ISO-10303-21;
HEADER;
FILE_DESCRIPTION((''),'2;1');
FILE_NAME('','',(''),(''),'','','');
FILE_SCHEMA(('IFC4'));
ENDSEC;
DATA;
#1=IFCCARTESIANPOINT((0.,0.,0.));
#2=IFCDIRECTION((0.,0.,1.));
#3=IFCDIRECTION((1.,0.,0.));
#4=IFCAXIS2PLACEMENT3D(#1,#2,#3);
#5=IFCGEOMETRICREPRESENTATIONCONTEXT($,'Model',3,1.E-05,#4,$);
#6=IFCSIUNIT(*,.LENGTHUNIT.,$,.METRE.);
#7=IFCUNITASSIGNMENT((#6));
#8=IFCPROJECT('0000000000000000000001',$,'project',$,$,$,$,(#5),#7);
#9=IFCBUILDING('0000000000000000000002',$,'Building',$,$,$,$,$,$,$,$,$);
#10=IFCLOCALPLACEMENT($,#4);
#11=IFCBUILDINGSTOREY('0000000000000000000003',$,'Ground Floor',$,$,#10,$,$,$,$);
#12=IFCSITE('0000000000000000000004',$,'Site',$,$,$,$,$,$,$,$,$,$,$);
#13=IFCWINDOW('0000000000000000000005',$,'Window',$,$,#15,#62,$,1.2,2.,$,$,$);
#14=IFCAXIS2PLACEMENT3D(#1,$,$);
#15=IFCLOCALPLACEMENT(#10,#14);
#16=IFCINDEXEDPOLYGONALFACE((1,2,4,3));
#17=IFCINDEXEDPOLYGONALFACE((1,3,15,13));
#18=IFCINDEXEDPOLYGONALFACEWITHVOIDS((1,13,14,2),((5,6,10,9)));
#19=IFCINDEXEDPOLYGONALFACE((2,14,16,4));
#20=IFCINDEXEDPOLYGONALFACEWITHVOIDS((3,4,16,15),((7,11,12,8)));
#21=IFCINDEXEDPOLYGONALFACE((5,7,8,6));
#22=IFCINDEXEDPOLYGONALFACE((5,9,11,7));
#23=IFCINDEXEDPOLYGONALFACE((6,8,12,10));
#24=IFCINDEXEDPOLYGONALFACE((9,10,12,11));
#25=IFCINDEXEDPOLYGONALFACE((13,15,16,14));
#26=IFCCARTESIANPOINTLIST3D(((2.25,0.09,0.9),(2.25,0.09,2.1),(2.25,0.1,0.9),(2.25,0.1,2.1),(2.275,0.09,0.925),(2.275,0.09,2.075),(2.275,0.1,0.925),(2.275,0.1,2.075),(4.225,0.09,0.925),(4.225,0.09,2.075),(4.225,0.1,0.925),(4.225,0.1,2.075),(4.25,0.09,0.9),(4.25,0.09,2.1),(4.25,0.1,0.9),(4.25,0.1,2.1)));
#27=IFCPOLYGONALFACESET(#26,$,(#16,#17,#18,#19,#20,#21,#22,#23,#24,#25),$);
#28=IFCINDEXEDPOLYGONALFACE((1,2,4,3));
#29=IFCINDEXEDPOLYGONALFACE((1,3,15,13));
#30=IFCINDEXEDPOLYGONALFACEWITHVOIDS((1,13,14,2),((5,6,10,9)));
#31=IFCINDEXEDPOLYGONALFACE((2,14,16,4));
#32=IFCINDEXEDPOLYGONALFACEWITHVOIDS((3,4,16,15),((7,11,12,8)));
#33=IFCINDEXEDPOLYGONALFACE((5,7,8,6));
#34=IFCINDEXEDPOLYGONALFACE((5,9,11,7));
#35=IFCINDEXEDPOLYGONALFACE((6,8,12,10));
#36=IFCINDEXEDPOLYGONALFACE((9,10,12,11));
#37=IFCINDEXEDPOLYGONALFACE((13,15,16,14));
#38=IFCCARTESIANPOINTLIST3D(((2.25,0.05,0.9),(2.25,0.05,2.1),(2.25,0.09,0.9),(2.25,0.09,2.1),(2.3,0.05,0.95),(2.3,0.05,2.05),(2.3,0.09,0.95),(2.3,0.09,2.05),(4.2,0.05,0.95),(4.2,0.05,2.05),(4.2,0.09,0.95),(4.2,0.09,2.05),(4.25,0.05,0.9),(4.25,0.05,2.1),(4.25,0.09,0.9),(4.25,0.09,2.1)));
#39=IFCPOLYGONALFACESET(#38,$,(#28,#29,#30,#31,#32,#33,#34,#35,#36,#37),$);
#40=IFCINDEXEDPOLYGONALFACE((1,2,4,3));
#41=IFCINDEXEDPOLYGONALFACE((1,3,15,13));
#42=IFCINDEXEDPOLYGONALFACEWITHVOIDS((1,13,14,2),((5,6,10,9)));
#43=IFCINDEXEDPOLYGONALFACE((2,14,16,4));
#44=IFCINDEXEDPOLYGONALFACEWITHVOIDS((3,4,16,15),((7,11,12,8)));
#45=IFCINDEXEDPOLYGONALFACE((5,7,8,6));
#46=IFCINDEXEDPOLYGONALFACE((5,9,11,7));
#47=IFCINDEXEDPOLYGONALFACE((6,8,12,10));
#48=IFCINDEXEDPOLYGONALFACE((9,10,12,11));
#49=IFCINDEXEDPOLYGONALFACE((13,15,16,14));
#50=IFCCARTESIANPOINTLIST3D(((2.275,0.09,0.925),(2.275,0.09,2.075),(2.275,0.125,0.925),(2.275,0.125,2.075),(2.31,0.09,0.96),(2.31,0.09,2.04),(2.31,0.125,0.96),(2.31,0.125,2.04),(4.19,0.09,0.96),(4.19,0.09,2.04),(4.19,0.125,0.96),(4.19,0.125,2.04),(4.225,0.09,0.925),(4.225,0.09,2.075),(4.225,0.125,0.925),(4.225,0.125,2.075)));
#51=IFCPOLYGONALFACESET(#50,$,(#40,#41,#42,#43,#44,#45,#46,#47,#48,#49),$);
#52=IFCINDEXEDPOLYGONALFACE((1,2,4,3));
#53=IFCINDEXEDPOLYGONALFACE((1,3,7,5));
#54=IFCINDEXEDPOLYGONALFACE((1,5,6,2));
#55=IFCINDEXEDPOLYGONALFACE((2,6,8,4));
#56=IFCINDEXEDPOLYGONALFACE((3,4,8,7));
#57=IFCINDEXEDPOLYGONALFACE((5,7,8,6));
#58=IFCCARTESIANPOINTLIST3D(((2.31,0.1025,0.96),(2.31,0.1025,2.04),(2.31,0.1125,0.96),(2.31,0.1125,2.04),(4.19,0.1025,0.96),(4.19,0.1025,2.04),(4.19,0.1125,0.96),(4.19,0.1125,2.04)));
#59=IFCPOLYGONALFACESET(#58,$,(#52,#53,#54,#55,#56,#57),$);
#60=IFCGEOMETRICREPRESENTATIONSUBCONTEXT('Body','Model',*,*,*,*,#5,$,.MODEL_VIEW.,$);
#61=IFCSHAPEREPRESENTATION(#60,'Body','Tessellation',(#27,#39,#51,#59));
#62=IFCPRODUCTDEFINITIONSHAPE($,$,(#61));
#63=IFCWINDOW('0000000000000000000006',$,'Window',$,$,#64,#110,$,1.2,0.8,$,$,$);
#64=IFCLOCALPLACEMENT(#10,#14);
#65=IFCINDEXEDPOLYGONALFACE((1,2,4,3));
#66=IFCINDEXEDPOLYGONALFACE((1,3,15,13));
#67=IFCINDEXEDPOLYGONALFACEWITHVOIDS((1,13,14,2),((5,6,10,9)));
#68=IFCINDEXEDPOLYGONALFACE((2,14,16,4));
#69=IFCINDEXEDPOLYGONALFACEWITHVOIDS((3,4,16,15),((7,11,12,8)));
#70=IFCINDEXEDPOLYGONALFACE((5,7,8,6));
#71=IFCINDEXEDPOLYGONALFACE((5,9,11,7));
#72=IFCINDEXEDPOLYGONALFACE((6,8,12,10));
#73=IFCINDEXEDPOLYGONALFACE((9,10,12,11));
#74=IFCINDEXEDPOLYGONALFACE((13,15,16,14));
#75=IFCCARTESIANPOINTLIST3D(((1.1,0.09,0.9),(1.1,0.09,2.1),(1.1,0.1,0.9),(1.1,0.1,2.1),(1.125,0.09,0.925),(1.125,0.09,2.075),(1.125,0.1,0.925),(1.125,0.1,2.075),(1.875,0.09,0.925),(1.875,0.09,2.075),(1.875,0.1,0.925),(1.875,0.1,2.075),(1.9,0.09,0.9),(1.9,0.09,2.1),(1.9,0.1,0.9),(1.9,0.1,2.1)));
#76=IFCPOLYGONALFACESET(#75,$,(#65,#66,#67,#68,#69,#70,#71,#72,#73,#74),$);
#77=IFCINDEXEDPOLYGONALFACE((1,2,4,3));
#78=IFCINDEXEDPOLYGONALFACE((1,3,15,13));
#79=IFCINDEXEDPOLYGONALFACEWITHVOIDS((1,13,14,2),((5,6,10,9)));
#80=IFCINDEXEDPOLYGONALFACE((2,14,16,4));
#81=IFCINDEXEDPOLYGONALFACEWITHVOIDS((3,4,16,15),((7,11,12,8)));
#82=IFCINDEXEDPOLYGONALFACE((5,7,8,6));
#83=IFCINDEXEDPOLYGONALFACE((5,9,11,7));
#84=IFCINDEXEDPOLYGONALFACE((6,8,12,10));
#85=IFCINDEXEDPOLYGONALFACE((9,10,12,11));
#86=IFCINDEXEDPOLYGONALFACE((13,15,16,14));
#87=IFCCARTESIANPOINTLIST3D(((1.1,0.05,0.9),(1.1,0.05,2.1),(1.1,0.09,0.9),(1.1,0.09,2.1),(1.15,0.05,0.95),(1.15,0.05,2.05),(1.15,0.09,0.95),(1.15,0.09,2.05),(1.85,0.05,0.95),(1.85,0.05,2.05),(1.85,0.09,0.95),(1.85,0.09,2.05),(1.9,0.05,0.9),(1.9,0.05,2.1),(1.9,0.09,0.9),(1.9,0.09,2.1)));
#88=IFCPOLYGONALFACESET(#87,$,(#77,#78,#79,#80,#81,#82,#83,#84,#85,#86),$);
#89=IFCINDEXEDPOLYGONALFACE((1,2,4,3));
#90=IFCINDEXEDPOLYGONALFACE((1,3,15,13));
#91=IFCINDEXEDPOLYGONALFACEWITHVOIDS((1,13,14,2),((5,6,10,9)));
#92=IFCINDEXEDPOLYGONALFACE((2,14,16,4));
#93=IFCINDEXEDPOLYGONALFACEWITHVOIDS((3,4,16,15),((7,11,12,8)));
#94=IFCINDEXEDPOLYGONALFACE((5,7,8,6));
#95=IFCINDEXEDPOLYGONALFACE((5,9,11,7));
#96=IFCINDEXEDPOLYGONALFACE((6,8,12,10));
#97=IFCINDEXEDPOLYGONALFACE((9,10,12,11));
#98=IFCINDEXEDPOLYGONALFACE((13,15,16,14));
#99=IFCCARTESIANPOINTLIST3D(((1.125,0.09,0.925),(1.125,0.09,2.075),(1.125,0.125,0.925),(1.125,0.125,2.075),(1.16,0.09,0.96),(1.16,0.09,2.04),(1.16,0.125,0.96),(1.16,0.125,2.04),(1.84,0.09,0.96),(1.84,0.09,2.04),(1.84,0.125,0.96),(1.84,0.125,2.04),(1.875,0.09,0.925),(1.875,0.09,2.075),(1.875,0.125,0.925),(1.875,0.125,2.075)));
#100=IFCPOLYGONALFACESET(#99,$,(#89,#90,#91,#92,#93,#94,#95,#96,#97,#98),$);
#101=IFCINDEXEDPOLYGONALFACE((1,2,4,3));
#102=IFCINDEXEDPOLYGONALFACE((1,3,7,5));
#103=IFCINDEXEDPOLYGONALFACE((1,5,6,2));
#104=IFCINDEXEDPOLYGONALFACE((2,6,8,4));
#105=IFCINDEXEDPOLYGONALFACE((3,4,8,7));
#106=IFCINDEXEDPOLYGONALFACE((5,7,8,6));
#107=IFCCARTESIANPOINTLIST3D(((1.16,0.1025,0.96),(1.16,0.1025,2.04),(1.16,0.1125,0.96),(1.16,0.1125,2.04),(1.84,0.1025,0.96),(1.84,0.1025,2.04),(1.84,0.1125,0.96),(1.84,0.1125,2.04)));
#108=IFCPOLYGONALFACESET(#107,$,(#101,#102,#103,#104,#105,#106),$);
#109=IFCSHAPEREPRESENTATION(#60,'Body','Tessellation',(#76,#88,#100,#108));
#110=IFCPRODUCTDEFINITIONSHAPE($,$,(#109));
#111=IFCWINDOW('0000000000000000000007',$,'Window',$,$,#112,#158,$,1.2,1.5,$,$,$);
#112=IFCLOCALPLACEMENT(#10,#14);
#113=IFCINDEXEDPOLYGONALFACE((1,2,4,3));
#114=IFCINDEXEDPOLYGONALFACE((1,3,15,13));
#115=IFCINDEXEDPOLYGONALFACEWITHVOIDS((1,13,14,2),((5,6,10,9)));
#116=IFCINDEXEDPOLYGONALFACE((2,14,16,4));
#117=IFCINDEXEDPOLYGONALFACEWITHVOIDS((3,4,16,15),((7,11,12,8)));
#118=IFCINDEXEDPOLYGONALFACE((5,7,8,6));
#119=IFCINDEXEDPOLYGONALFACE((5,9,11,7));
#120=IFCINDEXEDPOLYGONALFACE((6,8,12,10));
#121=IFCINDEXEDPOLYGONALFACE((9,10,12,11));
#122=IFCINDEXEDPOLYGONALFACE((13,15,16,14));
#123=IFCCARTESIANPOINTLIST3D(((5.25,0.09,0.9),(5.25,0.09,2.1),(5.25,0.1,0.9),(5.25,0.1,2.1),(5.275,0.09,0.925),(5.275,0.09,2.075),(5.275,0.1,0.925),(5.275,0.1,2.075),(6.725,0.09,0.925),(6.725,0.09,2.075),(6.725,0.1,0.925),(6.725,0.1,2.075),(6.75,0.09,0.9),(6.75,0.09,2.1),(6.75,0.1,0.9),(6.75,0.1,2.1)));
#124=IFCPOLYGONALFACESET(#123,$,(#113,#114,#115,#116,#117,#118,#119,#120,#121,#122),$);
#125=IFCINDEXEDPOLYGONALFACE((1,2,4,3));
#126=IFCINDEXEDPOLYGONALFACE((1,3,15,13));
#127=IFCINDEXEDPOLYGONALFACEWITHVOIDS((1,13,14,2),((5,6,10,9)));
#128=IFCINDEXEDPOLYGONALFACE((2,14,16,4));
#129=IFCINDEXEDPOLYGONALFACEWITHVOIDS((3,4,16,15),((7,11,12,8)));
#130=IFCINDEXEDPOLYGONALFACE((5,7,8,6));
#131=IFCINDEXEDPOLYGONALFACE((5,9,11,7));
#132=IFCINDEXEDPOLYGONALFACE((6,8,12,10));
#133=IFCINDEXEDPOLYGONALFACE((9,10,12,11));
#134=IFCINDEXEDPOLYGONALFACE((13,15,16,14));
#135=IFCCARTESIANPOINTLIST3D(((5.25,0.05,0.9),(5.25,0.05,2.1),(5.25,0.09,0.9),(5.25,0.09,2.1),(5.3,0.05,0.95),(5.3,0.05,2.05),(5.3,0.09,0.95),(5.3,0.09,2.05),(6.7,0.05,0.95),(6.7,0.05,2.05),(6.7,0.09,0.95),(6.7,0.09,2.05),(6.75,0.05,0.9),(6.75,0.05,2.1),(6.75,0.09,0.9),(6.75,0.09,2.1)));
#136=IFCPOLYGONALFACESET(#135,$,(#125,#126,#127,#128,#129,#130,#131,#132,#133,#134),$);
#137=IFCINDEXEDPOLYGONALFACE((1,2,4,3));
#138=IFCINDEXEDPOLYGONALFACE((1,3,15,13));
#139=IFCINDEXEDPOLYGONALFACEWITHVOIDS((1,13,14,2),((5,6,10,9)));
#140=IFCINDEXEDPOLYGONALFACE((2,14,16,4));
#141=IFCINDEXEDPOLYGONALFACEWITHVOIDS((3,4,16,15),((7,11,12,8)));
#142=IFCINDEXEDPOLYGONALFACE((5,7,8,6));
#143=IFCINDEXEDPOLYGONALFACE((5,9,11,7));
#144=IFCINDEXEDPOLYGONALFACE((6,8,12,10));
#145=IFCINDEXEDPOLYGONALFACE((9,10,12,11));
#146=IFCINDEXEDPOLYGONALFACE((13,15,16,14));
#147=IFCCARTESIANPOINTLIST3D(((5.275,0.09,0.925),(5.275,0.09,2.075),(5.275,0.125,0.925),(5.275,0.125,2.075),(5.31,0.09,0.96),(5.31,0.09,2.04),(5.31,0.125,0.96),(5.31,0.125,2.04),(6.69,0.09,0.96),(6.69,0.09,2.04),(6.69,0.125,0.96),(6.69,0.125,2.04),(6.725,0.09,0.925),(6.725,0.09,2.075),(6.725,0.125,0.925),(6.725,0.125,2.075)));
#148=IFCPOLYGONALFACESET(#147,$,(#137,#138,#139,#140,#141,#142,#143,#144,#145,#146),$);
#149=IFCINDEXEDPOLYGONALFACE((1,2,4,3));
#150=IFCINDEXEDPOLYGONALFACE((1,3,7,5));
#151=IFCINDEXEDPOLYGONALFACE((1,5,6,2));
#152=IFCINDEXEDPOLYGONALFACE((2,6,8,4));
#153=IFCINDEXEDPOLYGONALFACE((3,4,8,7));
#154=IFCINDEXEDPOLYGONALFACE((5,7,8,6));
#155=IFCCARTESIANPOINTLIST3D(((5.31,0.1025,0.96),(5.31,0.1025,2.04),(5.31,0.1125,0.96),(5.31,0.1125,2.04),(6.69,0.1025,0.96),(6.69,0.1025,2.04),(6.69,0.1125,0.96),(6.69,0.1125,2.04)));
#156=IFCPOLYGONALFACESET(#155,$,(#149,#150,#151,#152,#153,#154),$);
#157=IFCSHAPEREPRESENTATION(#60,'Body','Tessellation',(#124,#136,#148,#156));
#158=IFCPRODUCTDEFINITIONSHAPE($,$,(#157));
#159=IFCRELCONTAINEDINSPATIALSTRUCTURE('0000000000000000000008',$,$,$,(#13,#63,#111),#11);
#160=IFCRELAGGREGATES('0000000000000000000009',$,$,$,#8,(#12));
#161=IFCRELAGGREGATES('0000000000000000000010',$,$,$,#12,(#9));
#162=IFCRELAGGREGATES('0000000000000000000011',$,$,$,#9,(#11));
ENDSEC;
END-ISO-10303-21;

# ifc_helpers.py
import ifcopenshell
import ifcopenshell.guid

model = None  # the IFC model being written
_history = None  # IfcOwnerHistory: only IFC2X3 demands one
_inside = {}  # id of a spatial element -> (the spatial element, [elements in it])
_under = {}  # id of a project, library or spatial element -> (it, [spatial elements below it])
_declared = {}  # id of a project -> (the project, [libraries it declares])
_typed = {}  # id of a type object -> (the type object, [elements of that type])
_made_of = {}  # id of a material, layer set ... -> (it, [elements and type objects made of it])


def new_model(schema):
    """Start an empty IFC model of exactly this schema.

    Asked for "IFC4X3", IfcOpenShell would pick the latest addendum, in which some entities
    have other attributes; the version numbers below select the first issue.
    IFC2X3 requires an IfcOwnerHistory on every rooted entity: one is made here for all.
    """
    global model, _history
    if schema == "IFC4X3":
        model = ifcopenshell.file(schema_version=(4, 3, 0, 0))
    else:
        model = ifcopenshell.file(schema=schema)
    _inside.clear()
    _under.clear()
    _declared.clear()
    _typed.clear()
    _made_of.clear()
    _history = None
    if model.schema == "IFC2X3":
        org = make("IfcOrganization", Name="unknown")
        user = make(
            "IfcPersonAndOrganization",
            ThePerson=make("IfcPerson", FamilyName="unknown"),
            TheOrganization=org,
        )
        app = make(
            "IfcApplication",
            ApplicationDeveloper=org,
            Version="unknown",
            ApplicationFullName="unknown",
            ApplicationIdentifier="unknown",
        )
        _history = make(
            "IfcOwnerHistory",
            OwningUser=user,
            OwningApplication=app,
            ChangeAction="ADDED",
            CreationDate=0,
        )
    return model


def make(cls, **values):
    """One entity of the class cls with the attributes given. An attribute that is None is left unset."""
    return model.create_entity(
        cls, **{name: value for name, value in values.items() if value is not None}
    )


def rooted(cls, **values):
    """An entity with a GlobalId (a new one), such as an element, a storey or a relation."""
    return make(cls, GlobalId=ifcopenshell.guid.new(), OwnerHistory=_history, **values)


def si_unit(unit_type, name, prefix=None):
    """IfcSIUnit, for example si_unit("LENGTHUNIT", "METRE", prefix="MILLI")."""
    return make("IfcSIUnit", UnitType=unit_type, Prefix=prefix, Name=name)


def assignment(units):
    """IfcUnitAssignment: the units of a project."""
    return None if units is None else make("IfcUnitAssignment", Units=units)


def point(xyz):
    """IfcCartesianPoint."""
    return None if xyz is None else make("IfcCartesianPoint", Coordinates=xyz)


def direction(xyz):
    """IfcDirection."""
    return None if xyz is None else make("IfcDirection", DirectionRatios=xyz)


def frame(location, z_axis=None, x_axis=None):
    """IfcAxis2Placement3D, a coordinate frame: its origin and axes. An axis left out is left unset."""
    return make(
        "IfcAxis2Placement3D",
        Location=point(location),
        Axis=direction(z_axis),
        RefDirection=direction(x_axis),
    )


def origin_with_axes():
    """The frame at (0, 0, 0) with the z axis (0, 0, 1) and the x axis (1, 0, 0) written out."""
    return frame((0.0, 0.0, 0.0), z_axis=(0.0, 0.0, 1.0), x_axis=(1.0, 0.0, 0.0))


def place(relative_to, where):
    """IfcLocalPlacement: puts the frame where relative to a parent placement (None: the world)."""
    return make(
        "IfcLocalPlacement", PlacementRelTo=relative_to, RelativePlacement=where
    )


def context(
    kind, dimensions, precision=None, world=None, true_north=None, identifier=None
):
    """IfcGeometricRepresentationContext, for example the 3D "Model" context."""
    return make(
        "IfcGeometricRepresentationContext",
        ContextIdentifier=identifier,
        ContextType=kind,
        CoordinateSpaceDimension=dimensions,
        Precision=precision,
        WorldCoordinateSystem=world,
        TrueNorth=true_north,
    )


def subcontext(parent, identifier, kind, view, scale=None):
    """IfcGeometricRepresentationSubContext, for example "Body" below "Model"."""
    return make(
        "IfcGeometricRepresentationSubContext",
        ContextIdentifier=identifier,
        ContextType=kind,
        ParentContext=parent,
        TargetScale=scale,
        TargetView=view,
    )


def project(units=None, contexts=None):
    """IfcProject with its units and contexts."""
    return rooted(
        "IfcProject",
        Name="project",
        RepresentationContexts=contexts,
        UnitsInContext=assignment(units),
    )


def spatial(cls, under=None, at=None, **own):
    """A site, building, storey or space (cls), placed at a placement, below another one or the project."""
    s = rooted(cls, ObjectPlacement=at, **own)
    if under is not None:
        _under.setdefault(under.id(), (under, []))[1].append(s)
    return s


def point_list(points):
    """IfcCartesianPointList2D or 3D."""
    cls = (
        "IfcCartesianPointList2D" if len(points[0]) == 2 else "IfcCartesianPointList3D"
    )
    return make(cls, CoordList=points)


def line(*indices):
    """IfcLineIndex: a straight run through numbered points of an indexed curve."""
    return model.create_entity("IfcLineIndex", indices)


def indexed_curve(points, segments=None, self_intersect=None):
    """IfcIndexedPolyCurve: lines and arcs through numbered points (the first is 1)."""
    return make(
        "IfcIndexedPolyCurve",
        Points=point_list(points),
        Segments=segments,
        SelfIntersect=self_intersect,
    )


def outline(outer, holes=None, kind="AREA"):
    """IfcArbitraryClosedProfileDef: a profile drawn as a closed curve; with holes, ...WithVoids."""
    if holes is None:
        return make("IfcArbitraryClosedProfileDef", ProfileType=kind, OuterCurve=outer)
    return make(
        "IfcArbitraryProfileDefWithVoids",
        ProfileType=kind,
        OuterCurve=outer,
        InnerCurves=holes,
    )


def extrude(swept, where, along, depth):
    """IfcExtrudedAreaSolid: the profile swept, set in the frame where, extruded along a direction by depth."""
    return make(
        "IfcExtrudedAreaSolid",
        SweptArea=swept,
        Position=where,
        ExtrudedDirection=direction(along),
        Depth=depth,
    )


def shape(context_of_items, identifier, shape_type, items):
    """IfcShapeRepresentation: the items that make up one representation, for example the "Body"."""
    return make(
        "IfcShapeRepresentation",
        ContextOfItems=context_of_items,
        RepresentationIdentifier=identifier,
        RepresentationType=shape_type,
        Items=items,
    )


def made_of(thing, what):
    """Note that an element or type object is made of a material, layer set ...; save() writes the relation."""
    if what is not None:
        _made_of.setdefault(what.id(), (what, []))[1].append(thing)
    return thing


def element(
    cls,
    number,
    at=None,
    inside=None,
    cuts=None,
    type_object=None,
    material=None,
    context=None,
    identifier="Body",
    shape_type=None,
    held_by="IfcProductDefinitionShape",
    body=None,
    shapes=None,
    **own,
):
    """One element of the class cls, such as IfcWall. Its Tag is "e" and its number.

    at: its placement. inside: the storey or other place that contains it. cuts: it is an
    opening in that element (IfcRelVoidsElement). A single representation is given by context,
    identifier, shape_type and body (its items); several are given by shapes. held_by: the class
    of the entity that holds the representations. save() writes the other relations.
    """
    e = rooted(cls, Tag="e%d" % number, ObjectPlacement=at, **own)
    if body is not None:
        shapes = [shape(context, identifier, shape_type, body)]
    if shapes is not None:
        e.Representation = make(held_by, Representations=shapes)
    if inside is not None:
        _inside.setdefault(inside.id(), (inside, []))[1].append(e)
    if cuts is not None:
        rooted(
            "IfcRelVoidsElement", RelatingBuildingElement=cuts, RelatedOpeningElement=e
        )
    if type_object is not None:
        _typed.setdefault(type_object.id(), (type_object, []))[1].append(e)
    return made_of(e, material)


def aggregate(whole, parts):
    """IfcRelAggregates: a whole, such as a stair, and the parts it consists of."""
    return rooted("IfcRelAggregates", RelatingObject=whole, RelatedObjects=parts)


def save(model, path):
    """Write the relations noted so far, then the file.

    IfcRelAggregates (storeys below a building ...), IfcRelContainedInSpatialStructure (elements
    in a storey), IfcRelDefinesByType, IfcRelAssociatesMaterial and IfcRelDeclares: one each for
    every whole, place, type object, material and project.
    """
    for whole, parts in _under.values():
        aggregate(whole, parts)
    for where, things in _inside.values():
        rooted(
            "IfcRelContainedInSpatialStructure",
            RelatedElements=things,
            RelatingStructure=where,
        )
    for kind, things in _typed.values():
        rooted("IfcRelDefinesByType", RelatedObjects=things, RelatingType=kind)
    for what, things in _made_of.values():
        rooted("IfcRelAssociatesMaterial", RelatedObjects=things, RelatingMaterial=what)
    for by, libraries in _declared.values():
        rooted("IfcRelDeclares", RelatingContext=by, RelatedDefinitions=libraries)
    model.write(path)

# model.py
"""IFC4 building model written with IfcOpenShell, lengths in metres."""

from ifc_helpers import new_model, si_unit, frame, origin_with_axes, place, context, subcontext, project, spatial, line, indexed_curve, outline, extrude, element, save


model = new_model("IFC4")

# Units and contexts
model_context = context("Model", 3, precision=1e-05, world=origin_with_axes())
body_context = subcontext(model_context, "Body", "Model", "MODEL_VIEW")
ifc_project = project(units=[si_unit("LENGTHUNIT", "METRE")], contexts=[model_context])

# Site, building, storey
site = spatial("IfcSite", under=ifc_project, Name="Site")
building = spatial("IfcBuilding", under=site, Name="Building")
storey_placement = place(None, origin_with_axes())
storey = spatial("IfcBuildingStorey", under=building, at=storey_placement, Name="Ground Floor")

# Windows
window_1_placement = place(storey_placement, frame((2.25, 0.0, 0.9), z_axis=(0.0, 0.0, 1.0), x_axis=(1.0, 0.0, 0.0)))
element("IfcWindow", 1, at=window_1_placement, inside=storey, Name="Window", OverallHeight=1.2, OverallWidth=2.0, context=body_context, shape_type="SweptSolid", body=[
    extrude(outline(indexed_curve([(0.0, 0.0), (2.0, 0.0), (2.0, 1.2), (0.0, 1.2)], segments=[line(1, 2, 3, 4, 1)]), holes=[indexed_curve([(0.025, 0.025), (1.975, 0.025), (1.975, 1.175), (0.025, 1.175)], segments=[line(1, 2, 3, 4, 1)])]), frame((0.0, 0.09, 0.0), z_axis=(0.0, -1.0, 0.0), x_axis=(1.0, 0.0, 0.0)), (0.0, 0.0, -1.0), 0.01),
    extrude(outline(indexed_curve([(0.0, 0.0), (2.0, 0.0), (2.0, 1.2), (0.0, 1.2)], segments=[line(1, 2, 3, 4, 1)]), holes=[indexed_curve([(0.05, 0.05), (1.95, 0.05), (1.95, 1.15), (0.05, 1.15)], segments=[line(1, 2, 3, 4, 1)])]), frame((0.0, 0.05, 0.0), z_axis=(0.0, -1.0, 0.0), x_axis=(1.0, 0.0, 0.0)), (0.0, 0.0, -1.0), 0.04),
    extrude(outline(indexed_curve([(0.0, 0.0), (1.95, 0.0), (1.95, 1.15), (0.0, 1.15)], segments=[line(1, 2, 3, 4, 1)]), holes=[indexed_curve([(0.035, 0.035), (1.915, 0.035), (1.915, 1.115), (0.035, 1.115)], segments=[line(1, 2, 3, 4, 1)])]), frame((0.025, 0.09, 0.025), z_axis=(0.0, -1.0, 0.0), x_axis=(1.0, 0.0, 0.0)), (0.0, 0.0, -1.0), 0.035),
    extrude(outline(indexed_curve([(0.035, 0.035), (1.915, 0.035), (1.915, 1.115), (0.035, 1.115)], segments=[line(1, 2, 3, 4, 1)])), frame((0.025, 0.1025, 0.025), z_axis=(0.0, -1.0, 0.0), x_axis=(1.0, 0.0, 0.0)), (0.0, 0.0, -1.0), 0.01),
])
window_2_placement = place(storey_placement, frame((1.1, 0.0, 0.9), z_axis=(0.0, 0.0, 1.0), x_axis=(1.0, 0.0, 0.0)))
element("IfcWindow", 2, at=window_2_placement, inside=storey, Name="Window", OverallHeight=1.2, OverallWidth=0.8, context=body_context, shape_type="SweptSolid", body=[
    extrude(outline(indexed_curve([(0.0, 0.0), (0.8, 0.0), (0.8, 1.2), (0.0, 1.2)], segments=[line(1, 2, 3, 4, 1)]), holes=[indexed_curve([(0.025, 0.025), (0.775, 0.025), (0.775, 1.175), (0.025, 1.175)], segments=[line(1, 2, 3, 4, 1)])]), frame((0.0, 0.09, 0.0), z_axis=(0.0, -1.0, 0.0), x_axis=(1.0, 0.0, 0.0)), (0.0, 0.0, -1.0), 0.01),
    extrude(outline(indexed_curve([(0.0, 0.0), (0.8, 0.0), (0.8, 1.2), (0.0, 1.2)], segments=[line(1, 2, 3, 4, 1)]), holes=[indexed_curve([(0.05, 0.05), (0.75, 0.05), (0.75, 1.15), (0.05, 1.15)], segments=[line(1, 2, 3, 4, 1)])]), frame((0.0, 0.05, 0.0), z_axis=(0.0, -1.0, 0.0), x_axis=(1.0, 0.0, 0.0)), (0.0, 0.0, -1.0), 0.04),
    extrude(outline(indexed_curve([(0.0, 0.0), (0.75, 0.0), (0.75, 1.15), (0.0, 1.15)], segments=[line(1, 2, 3, 4, 1)]), holes=[indexed_curve([(0.035, 0.035), (0.715, 0.035), (0.715, 1.115), (0.035, 1.115)], segments=[line(1, 2, 3, 4, 1)])]), frame((0.025, 0.09, 0.025), z_axis=(0.0, -1.0, 0.0), x_axis=(1.0, 0.0, 0.0)), (0.0, 0.0, -1.0), 0.035),
    extrude(outline(indexed_curve([(0.035, 0.035), (0.715, 0.035), (0.715, 1.115), (0.035, 1.115)], segments=[line(1, 2, 3, 4, 1)])), frame((0.025, 0.1025, 0.025), z_axis=(0.0, -1.0, 0.0), x_axis=(1.0, 0.0, 0.0)), (0.0, 0.0, -1.0), 0.01),
])
window_3_placement = place(storey_placement, frame((5.25, 0.0, 0.9), z_axis=(0.0, 0.0, 1.0), x_axis=(1.0, 0.0, 0.0)))
element("IfcWindow", 3, at=window_3_placement, inside=storey, Name="Window", OverallHeight=1.2, OverallWidth=1.5, context=body_context, shape_type="SweptSolid", body=[
    extrude(outline(indexed_curve([(0.0, 0.0), (1.5, 0.0), (1.5, 1.2), (0.0, 1.2)], segments=[line(1, 2, 3, 4, 1)]), holes=[indexed_curve([(0.025, 0.025), (1.475, 0.025), (1.475, 1.175), (0.025, 1.175)], segments=[line(1, 2, 3, 4, 1)])]), frame((0.0, 0.09, 0.0), z_axis=(0.0, -1.0, 0.0), x_axis=(1.0, 0.0, 0.0)), (0.0, 0.0, -1.0), 0.01),
    extrude(outline(indexed_curve([(0.0, 0.0), (1.5, 0.0), (1.5, 1.2), (0.0, 1.2)], segments=[line(1, 2, 3, 4, 1)]), holes=[indexed_curve([(0.05, 0.05), (1.45, 0.05), (1.45, 1.15), (0.05, 1.15)], segments=[line(1, 2, 3, 4, 1)])]), frame((0.0, 0.05, 0.0), z_axis=(0.0, -1.0, 0.0), x_axis=(1.0, 0.0, 0.0)), (0.0, 0.0, -1.0), 0.04),
    extrude(outline(indexed_curve([(0.0, 0.0), (1.45, 0.0), (1.45, 1.15), (0.0, 1.15)], segments=[line(1, 2, 3, 4, 1)]), holes=[indexed_curve([(0.035, 0.035), (1.415, 0.035), (1.415, 1.115), (0.035, 1.115)], segments=[line(1, 2, 3, 4, 1)])]), frame((0.025, 0.09, 0.025), z_axis=(0.0, -1.0, 0.0), x_axis=(1.0, 0.0, 0.0)), (0.0, 0.0, -1.0), 0.035),
    extrude(outline(indexed_curve([(0.035, 0.035), (1.415, 0.035), (1.415, 1.115), (0.035, 1.115)], segments=[line(1, 2, 3, 4, 1)])), frame((0.025, 0.1025, 0.025), z_axis=(0.0, -1.0, 0.0), x_axis=(1.0, 0.0, 0.0)), (0.0, 0.0, -1.0), 0.01),
])

save(model, "model.ifc")
